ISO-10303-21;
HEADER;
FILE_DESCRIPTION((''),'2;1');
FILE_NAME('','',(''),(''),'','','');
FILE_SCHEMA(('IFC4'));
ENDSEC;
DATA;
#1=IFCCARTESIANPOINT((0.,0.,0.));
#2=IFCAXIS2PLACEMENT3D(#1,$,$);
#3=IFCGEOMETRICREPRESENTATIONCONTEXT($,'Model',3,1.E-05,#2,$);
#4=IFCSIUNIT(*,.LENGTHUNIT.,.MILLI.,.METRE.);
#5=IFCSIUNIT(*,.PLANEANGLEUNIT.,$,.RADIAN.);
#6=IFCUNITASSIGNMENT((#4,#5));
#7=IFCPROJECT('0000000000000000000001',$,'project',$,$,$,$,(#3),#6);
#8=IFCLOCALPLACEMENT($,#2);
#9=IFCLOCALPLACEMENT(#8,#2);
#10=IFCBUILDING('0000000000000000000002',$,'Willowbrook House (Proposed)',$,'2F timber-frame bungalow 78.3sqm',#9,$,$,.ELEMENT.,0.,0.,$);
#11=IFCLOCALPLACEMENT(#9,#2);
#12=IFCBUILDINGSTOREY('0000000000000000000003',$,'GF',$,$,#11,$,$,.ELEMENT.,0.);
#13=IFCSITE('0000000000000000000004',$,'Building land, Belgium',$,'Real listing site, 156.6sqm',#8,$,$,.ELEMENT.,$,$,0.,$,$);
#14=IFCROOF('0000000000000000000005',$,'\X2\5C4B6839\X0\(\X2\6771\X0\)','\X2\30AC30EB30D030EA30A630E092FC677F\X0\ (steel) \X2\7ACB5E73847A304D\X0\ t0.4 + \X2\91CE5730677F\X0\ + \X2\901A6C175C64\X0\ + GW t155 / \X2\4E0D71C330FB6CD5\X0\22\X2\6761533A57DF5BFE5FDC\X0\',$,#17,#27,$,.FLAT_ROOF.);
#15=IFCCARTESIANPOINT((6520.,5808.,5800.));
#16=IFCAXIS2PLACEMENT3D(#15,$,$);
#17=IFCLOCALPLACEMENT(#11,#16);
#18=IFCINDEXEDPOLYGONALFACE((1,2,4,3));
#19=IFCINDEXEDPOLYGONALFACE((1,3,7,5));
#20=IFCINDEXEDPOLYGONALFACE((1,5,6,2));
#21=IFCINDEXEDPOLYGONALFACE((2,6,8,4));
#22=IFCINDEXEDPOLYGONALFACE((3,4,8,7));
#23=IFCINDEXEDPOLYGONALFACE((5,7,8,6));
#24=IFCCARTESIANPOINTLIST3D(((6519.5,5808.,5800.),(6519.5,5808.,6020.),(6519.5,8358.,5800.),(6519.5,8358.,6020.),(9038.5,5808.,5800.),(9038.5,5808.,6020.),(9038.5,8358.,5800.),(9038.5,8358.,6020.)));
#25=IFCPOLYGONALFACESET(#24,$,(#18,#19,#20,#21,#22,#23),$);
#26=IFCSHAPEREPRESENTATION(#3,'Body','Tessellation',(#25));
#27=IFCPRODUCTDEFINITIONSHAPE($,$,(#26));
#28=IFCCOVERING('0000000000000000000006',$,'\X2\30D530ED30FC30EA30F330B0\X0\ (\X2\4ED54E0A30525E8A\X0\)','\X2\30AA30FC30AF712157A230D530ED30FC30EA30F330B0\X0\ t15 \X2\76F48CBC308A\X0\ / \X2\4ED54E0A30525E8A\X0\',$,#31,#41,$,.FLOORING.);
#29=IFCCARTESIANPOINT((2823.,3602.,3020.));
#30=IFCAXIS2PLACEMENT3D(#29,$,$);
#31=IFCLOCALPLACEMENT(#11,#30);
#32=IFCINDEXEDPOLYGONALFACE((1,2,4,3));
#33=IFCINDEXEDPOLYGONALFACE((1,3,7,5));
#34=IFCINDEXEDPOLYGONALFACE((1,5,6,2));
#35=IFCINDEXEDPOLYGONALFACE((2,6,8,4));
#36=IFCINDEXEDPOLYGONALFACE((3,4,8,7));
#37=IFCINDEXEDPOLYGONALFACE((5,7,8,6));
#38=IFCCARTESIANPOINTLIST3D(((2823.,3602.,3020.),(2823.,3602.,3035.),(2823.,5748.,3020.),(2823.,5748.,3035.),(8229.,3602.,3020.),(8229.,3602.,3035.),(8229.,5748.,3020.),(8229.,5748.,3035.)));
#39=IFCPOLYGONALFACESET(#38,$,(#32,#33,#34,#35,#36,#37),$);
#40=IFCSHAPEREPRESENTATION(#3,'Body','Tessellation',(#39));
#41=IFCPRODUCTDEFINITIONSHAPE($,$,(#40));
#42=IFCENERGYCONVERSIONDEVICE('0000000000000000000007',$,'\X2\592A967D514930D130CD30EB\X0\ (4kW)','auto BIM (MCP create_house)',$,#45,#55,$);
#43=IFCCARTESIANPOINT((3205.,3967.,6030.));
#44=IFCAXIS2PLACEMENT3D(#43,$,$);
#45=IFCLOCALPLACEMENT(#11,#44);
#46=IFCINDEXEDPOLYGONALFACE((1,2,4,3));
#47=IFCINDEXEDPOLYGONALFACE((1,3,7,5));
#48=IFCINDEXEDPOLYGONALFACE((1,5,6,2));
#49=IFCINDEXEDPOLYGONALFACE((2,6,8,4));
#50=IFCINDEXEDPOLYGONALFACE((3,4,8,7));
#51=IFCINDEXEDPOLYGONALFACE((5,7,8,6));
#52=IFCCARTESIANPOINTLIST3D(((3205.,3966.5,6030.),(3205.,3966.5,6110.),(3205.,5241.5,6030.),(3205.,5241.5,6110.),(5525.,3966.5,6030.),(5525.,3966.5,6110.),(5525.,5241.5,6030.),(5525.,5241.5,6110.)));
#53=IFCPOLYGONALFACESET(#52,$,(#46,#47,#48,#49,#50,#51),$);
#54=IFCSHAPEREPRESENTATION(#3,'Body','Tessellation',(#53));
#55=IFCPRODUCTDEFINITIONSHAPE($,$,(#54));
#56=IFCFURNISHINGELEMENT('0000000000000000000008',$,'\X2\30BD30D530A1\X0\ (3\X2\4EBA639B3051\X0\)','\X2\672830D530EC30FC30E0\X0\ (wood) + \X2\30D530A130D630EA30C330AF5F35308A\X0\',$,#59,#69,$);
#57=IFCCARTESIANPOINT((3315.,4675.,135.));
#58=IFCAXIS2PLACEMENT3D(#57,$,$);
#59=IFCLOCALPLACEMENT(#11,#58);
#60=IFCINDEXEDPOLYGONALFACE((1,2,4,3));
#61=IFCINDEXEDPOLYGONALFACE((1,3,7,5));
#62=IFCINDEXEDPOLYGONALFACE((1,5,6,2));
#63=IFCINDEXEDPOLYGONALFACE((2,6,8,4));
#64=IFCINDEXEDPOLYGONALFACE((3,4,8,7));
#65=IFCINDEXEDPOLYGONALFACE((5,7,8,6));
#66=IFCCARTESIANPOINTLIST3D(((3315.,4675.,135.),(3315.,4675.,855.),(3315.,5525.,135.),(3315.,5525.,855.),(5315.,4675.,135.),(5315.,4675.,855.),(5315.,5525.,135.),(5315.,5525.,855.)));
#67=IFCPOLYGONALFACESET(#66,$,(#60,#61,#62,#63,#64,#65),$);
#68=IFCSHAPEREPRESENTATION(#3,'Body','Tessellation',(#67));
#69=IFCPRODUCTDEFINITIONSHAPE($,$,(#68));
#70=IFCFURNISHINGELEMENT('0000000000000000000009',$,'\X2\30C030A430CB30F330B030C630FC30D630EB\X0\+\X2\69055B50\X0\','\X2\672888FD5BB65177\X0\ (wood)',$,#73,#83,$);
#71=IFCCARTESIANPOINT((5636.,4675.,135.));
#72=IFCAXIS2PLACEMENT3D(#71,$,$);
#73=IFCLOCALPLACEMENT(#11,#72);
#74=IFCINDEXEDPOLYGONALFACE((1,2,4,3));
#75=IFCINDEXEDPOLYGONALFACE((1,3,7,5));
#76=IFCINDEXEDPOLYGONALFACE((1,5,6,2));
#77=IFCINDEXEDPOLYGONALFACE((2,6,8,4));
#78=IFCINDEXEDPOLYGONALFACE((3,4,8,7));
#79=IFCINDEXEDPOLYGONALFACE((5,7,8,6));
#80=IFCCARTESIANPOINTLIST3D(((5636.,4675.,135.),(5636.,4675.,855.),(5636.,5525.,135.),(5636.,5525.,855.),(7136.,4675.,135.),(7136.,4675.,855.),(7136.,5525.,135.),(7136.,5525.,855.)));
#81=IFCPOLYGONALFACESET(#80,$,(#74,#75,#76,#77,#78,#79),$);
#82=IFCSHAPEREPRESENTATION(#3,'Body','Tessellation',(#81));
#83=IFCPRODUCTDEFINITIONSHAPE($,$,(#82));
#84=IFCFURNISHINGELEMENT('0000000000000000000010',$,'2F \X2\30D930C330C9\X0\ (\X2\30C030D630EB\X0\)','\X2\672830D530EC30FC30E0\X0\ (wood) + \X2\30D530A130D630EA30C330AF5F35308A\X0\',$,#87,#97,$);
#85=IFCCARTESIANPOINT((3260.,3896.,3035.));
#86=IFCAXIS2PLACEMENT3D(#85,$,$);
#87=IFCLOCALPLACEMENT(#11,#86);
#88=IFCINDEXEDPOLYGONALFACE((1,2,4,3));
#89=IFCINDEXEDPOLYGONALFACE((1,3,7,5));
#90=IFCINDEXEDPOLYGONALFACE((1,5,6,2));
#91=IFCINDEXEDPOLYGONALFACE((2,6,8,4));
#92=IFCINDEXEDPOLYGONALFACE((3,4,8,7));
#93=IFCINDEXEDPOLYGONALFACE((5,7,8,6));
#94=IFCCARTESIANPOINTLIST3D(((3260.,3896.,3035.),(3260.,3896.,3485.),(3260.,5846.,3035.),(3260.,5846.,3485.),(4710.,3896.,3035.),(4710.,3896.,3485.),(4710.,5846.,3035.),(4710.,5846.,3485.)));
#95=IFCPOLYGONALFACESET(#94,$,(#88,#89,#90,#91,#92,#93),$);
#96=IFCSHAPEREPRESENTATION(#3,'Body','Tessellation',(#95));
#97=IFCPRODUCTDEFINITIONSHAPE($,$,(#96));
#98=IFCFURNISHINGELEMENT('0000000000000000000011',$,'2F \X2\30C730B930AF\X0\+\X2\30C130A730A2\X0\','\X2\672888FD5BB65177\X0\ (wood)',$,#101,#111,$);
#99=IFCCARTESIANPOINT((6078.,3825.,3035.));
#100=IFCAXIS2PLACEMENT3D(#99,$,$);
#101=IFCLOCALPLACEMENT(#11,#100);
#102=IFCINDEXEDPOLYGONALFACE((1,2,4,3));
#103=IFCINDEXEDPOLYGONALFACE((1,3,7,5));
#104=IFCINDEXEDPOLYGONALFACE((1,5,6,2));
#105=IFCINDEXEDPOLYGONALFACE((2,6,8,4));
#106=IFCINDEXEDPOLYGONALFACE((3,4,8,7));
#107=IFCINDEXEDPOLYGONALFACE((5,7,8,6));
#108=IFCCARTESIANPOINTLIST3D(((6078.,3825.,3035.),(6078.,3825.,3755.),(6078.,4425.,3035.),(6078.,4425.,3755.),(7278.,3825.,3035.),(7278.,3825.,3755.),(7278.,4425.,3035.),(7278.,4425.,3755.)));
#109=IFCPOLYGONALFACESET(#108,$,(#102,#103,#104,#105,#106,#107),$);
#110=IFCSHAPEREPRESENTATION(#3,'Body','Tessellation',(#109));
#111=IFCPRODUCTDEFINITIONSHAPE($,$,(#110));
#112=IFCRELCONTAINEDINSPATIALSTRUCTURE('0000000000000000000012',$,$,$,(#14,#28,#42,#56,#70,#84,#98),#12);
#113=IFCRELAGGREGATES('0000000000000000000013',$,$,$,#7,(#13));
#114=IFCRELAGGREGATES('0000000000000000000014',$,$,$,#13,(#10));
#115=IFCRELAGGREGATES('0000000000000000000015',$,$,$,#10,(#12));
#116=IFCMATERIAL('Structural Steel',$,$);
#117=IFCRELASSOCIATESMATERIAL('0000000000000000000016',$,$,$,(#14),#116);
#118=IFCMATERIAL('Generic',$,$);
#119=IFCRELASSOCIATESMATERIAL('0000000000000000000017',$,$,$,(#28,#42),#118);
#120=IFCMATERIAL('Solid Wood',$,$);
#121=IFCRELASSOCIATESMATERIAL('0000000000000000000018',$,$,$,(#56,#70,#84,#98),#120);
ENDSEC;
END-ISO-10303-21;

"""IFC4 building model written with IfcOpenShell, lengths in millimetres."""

from ifc_helpers import new_model, si_unit, frame, frame_2d, origin, place, context, project, spatial, rectangle, extrude, material, element, save


model = new_model("IFC4")

# Units and contexts
model_context = context("Model", 3, precision=1e-05, world=origin())
ifc_project = project(units=[si_unit("LENGTHUNIT", "METRE", prefix="MILLI"), si_unit("PLANEANGLEUNIT", "RADIAN")], contexts=[model_context])

# Site, building, storey
site_placement = place(None, origin())
site = spatial("IfcSite", under=ifc_project, at=site_placement, Name="Building land, Belgium", ObjectType="Real listing site, 156.6sqm", CompositionType="ELEMENT", RefElevation=0.0)
building_placement = place(site_placement, origin())
building = spatial("IfcBuilding", under=site, at=building_placement, Name="Willowbrook House (Proposed)", ObjectType="2F timber-frame bungalow 78.3sqm", CompositionType="ELEMENT", ElevationOfRefHeight=0.0, ElevationOfTerrain=0.0)
storey_placement = place(building_placement, origin())
storey = spatial("IfcBuildingStorey", under=building, at=storey_placement, Name="GF", CompositionType="ELEMENT", Elevation=0.0)

# Shared definitions
ifc_material_1 = material(Name="Solid Wood")

# Roof
ifc_material_2 = material(Name="Structural Steel")
roof_1_placement = place(storey_placement, frame((6520.0, 5808.0, 5800.0)))
element("IfcRoof", 1, at=roof_1_placement, inside=storey, material=ifc_material_2, Name="屋根(東)", Description="ガルバリウム鋼板 (steel) 立平葺き t0.4 + 野地板 + 通気層 + GW t155 / 不燃・法22条区域対応", PredefinedType="FLAT_ROOF", context=model_context, shape_type="SweptSolid", body=[
    extrude(rectangle(XDim=2519.0, YDim=2550.0, at=frame_2d((1259.0, 1275.0))), frame((6520.0, 5808.0, 5800.0)), (0.0, 0.0, 1.0), 220.0),
])

# Covering
ifc_material_3 = material(Name="Generic")
covering_placement = place(storey_placement, frame((2823.0, 3602.0, 3020.0)))
element("IfcCovering", 2, at=covering_placement, inside=storey, material=ifc_material_3, Name="フローリング (仕上げ床)", Description="オーク無垢フローリング t15 直貼り / 仕上げ床", PredefinedType="FLOORING", context=model_context, shape_type="SweptSolid", body=[
    extrude(rectangle(XDim=5406.0, YDim=2146.0, at=frame_2d((2703.0, 1073.0))), frame((2823.0, 3602.0, 3020.0)), (0.0, 0.0, 1.0), 15.0),
])

# Energy conversion device
energy_conversion_device_placement = place(storey_placement, frame((3205.0, 3967.0, 6030.0)))
element("IfcEnergyConversionDevice", 3, at=energy_conversion_device_placement, inside=storey, material=ifc_material_3, Name="太陽光パネル (4kW)", Description="auto BIM (MCP create_house)", context=model_context, shape_type="SweptSolid", body=[
    extrude(rectangle(XDim=2320.0, YDim=1275.0, at=frame_2d((1160.0, 637.0))), frame((3205.0, 3967.0, 6030.0)), (0.0, 0.0, 1.0), 80.0),
])

# Furnishing elements
furnishing_1_placement = place(storey_placement, frame((3315.0, 4675.0, 135.0)))
element("IfcFurnishingElement", 4, at=furnishing_1_placement, inside=storey, material=ifc_material_1, Name="ソファ (3人掛け)", Description="木フレーム (wood) + ファブリック張り", context=model_context, shape_type="SweptSolid", body=[
    extrude(rectangle(XDim=2000.0, YDim=850.0, at=frame_2d((1000.0, 425.0))), frame((3315.0, 4675.0, 135.0)), (0.0, 0.0, 1.0), 720.0),
])
furnishing_2_placement = place(storey_placement, frame((5636.0, 4675.0, 135.0)))
element("IfcFurnishingElement", 5, at=furnishing_2_placement, inside=storey, material=ifc_material_1, Name="ダイニングテーブル+椅子", Description="木製家具 (wood)", context=model_context, shape_type="SweptSolid", body=[
    extrude(rectangle(XDim=1500.0, YDim=850.0, at=frame_2d((750.0, 425.0))), frame((5636.0, 4675.0, 135.0)), (0.0, 0.0, 1.0), 720.0),
])
furnishing_3_placement = place(storey_placement, frame((3260.0, 3896.0, 3035.0)))
element("IfcFurnishingElement", 6, at=furnishing_3_placement, inside=storey, material=ifc_material_1, Name="2F ベッド (ダブル)", Description="木フレーム (wood) + ファブリック張り", context=model_context, shape_type="SweptSolid", body=[
    extrude(rectangle(XDim=1450.0, YDim=1950.0, at=frame_2d((725.0, 975.0))), frame((3260.0, 3896.0, 3035.0)), (0.0, 0.0, 1.0), 450.0),
])
furnishing_4_placement = place(storey_placement, frame((6078.0, 3825.0, 3035.0)))
element("IfcFurnishingElement", 7, at=furnishing_4_placement, inside=storey, material=ifc_material_1, Name="2F デスク+チェア", Description="木製家具 (wood)", context=model_context, shape_type="SweptSolid", body=[
    extrude(rectangle(XDim=1200.0, YDim=600.0, at=frame_2d((600.0, 300.0))), frame((6078.0, 3825.0, 3035.0)), (0.0, 0.0, 1.0), 720.0),
])

save(model, "model.ifc")
